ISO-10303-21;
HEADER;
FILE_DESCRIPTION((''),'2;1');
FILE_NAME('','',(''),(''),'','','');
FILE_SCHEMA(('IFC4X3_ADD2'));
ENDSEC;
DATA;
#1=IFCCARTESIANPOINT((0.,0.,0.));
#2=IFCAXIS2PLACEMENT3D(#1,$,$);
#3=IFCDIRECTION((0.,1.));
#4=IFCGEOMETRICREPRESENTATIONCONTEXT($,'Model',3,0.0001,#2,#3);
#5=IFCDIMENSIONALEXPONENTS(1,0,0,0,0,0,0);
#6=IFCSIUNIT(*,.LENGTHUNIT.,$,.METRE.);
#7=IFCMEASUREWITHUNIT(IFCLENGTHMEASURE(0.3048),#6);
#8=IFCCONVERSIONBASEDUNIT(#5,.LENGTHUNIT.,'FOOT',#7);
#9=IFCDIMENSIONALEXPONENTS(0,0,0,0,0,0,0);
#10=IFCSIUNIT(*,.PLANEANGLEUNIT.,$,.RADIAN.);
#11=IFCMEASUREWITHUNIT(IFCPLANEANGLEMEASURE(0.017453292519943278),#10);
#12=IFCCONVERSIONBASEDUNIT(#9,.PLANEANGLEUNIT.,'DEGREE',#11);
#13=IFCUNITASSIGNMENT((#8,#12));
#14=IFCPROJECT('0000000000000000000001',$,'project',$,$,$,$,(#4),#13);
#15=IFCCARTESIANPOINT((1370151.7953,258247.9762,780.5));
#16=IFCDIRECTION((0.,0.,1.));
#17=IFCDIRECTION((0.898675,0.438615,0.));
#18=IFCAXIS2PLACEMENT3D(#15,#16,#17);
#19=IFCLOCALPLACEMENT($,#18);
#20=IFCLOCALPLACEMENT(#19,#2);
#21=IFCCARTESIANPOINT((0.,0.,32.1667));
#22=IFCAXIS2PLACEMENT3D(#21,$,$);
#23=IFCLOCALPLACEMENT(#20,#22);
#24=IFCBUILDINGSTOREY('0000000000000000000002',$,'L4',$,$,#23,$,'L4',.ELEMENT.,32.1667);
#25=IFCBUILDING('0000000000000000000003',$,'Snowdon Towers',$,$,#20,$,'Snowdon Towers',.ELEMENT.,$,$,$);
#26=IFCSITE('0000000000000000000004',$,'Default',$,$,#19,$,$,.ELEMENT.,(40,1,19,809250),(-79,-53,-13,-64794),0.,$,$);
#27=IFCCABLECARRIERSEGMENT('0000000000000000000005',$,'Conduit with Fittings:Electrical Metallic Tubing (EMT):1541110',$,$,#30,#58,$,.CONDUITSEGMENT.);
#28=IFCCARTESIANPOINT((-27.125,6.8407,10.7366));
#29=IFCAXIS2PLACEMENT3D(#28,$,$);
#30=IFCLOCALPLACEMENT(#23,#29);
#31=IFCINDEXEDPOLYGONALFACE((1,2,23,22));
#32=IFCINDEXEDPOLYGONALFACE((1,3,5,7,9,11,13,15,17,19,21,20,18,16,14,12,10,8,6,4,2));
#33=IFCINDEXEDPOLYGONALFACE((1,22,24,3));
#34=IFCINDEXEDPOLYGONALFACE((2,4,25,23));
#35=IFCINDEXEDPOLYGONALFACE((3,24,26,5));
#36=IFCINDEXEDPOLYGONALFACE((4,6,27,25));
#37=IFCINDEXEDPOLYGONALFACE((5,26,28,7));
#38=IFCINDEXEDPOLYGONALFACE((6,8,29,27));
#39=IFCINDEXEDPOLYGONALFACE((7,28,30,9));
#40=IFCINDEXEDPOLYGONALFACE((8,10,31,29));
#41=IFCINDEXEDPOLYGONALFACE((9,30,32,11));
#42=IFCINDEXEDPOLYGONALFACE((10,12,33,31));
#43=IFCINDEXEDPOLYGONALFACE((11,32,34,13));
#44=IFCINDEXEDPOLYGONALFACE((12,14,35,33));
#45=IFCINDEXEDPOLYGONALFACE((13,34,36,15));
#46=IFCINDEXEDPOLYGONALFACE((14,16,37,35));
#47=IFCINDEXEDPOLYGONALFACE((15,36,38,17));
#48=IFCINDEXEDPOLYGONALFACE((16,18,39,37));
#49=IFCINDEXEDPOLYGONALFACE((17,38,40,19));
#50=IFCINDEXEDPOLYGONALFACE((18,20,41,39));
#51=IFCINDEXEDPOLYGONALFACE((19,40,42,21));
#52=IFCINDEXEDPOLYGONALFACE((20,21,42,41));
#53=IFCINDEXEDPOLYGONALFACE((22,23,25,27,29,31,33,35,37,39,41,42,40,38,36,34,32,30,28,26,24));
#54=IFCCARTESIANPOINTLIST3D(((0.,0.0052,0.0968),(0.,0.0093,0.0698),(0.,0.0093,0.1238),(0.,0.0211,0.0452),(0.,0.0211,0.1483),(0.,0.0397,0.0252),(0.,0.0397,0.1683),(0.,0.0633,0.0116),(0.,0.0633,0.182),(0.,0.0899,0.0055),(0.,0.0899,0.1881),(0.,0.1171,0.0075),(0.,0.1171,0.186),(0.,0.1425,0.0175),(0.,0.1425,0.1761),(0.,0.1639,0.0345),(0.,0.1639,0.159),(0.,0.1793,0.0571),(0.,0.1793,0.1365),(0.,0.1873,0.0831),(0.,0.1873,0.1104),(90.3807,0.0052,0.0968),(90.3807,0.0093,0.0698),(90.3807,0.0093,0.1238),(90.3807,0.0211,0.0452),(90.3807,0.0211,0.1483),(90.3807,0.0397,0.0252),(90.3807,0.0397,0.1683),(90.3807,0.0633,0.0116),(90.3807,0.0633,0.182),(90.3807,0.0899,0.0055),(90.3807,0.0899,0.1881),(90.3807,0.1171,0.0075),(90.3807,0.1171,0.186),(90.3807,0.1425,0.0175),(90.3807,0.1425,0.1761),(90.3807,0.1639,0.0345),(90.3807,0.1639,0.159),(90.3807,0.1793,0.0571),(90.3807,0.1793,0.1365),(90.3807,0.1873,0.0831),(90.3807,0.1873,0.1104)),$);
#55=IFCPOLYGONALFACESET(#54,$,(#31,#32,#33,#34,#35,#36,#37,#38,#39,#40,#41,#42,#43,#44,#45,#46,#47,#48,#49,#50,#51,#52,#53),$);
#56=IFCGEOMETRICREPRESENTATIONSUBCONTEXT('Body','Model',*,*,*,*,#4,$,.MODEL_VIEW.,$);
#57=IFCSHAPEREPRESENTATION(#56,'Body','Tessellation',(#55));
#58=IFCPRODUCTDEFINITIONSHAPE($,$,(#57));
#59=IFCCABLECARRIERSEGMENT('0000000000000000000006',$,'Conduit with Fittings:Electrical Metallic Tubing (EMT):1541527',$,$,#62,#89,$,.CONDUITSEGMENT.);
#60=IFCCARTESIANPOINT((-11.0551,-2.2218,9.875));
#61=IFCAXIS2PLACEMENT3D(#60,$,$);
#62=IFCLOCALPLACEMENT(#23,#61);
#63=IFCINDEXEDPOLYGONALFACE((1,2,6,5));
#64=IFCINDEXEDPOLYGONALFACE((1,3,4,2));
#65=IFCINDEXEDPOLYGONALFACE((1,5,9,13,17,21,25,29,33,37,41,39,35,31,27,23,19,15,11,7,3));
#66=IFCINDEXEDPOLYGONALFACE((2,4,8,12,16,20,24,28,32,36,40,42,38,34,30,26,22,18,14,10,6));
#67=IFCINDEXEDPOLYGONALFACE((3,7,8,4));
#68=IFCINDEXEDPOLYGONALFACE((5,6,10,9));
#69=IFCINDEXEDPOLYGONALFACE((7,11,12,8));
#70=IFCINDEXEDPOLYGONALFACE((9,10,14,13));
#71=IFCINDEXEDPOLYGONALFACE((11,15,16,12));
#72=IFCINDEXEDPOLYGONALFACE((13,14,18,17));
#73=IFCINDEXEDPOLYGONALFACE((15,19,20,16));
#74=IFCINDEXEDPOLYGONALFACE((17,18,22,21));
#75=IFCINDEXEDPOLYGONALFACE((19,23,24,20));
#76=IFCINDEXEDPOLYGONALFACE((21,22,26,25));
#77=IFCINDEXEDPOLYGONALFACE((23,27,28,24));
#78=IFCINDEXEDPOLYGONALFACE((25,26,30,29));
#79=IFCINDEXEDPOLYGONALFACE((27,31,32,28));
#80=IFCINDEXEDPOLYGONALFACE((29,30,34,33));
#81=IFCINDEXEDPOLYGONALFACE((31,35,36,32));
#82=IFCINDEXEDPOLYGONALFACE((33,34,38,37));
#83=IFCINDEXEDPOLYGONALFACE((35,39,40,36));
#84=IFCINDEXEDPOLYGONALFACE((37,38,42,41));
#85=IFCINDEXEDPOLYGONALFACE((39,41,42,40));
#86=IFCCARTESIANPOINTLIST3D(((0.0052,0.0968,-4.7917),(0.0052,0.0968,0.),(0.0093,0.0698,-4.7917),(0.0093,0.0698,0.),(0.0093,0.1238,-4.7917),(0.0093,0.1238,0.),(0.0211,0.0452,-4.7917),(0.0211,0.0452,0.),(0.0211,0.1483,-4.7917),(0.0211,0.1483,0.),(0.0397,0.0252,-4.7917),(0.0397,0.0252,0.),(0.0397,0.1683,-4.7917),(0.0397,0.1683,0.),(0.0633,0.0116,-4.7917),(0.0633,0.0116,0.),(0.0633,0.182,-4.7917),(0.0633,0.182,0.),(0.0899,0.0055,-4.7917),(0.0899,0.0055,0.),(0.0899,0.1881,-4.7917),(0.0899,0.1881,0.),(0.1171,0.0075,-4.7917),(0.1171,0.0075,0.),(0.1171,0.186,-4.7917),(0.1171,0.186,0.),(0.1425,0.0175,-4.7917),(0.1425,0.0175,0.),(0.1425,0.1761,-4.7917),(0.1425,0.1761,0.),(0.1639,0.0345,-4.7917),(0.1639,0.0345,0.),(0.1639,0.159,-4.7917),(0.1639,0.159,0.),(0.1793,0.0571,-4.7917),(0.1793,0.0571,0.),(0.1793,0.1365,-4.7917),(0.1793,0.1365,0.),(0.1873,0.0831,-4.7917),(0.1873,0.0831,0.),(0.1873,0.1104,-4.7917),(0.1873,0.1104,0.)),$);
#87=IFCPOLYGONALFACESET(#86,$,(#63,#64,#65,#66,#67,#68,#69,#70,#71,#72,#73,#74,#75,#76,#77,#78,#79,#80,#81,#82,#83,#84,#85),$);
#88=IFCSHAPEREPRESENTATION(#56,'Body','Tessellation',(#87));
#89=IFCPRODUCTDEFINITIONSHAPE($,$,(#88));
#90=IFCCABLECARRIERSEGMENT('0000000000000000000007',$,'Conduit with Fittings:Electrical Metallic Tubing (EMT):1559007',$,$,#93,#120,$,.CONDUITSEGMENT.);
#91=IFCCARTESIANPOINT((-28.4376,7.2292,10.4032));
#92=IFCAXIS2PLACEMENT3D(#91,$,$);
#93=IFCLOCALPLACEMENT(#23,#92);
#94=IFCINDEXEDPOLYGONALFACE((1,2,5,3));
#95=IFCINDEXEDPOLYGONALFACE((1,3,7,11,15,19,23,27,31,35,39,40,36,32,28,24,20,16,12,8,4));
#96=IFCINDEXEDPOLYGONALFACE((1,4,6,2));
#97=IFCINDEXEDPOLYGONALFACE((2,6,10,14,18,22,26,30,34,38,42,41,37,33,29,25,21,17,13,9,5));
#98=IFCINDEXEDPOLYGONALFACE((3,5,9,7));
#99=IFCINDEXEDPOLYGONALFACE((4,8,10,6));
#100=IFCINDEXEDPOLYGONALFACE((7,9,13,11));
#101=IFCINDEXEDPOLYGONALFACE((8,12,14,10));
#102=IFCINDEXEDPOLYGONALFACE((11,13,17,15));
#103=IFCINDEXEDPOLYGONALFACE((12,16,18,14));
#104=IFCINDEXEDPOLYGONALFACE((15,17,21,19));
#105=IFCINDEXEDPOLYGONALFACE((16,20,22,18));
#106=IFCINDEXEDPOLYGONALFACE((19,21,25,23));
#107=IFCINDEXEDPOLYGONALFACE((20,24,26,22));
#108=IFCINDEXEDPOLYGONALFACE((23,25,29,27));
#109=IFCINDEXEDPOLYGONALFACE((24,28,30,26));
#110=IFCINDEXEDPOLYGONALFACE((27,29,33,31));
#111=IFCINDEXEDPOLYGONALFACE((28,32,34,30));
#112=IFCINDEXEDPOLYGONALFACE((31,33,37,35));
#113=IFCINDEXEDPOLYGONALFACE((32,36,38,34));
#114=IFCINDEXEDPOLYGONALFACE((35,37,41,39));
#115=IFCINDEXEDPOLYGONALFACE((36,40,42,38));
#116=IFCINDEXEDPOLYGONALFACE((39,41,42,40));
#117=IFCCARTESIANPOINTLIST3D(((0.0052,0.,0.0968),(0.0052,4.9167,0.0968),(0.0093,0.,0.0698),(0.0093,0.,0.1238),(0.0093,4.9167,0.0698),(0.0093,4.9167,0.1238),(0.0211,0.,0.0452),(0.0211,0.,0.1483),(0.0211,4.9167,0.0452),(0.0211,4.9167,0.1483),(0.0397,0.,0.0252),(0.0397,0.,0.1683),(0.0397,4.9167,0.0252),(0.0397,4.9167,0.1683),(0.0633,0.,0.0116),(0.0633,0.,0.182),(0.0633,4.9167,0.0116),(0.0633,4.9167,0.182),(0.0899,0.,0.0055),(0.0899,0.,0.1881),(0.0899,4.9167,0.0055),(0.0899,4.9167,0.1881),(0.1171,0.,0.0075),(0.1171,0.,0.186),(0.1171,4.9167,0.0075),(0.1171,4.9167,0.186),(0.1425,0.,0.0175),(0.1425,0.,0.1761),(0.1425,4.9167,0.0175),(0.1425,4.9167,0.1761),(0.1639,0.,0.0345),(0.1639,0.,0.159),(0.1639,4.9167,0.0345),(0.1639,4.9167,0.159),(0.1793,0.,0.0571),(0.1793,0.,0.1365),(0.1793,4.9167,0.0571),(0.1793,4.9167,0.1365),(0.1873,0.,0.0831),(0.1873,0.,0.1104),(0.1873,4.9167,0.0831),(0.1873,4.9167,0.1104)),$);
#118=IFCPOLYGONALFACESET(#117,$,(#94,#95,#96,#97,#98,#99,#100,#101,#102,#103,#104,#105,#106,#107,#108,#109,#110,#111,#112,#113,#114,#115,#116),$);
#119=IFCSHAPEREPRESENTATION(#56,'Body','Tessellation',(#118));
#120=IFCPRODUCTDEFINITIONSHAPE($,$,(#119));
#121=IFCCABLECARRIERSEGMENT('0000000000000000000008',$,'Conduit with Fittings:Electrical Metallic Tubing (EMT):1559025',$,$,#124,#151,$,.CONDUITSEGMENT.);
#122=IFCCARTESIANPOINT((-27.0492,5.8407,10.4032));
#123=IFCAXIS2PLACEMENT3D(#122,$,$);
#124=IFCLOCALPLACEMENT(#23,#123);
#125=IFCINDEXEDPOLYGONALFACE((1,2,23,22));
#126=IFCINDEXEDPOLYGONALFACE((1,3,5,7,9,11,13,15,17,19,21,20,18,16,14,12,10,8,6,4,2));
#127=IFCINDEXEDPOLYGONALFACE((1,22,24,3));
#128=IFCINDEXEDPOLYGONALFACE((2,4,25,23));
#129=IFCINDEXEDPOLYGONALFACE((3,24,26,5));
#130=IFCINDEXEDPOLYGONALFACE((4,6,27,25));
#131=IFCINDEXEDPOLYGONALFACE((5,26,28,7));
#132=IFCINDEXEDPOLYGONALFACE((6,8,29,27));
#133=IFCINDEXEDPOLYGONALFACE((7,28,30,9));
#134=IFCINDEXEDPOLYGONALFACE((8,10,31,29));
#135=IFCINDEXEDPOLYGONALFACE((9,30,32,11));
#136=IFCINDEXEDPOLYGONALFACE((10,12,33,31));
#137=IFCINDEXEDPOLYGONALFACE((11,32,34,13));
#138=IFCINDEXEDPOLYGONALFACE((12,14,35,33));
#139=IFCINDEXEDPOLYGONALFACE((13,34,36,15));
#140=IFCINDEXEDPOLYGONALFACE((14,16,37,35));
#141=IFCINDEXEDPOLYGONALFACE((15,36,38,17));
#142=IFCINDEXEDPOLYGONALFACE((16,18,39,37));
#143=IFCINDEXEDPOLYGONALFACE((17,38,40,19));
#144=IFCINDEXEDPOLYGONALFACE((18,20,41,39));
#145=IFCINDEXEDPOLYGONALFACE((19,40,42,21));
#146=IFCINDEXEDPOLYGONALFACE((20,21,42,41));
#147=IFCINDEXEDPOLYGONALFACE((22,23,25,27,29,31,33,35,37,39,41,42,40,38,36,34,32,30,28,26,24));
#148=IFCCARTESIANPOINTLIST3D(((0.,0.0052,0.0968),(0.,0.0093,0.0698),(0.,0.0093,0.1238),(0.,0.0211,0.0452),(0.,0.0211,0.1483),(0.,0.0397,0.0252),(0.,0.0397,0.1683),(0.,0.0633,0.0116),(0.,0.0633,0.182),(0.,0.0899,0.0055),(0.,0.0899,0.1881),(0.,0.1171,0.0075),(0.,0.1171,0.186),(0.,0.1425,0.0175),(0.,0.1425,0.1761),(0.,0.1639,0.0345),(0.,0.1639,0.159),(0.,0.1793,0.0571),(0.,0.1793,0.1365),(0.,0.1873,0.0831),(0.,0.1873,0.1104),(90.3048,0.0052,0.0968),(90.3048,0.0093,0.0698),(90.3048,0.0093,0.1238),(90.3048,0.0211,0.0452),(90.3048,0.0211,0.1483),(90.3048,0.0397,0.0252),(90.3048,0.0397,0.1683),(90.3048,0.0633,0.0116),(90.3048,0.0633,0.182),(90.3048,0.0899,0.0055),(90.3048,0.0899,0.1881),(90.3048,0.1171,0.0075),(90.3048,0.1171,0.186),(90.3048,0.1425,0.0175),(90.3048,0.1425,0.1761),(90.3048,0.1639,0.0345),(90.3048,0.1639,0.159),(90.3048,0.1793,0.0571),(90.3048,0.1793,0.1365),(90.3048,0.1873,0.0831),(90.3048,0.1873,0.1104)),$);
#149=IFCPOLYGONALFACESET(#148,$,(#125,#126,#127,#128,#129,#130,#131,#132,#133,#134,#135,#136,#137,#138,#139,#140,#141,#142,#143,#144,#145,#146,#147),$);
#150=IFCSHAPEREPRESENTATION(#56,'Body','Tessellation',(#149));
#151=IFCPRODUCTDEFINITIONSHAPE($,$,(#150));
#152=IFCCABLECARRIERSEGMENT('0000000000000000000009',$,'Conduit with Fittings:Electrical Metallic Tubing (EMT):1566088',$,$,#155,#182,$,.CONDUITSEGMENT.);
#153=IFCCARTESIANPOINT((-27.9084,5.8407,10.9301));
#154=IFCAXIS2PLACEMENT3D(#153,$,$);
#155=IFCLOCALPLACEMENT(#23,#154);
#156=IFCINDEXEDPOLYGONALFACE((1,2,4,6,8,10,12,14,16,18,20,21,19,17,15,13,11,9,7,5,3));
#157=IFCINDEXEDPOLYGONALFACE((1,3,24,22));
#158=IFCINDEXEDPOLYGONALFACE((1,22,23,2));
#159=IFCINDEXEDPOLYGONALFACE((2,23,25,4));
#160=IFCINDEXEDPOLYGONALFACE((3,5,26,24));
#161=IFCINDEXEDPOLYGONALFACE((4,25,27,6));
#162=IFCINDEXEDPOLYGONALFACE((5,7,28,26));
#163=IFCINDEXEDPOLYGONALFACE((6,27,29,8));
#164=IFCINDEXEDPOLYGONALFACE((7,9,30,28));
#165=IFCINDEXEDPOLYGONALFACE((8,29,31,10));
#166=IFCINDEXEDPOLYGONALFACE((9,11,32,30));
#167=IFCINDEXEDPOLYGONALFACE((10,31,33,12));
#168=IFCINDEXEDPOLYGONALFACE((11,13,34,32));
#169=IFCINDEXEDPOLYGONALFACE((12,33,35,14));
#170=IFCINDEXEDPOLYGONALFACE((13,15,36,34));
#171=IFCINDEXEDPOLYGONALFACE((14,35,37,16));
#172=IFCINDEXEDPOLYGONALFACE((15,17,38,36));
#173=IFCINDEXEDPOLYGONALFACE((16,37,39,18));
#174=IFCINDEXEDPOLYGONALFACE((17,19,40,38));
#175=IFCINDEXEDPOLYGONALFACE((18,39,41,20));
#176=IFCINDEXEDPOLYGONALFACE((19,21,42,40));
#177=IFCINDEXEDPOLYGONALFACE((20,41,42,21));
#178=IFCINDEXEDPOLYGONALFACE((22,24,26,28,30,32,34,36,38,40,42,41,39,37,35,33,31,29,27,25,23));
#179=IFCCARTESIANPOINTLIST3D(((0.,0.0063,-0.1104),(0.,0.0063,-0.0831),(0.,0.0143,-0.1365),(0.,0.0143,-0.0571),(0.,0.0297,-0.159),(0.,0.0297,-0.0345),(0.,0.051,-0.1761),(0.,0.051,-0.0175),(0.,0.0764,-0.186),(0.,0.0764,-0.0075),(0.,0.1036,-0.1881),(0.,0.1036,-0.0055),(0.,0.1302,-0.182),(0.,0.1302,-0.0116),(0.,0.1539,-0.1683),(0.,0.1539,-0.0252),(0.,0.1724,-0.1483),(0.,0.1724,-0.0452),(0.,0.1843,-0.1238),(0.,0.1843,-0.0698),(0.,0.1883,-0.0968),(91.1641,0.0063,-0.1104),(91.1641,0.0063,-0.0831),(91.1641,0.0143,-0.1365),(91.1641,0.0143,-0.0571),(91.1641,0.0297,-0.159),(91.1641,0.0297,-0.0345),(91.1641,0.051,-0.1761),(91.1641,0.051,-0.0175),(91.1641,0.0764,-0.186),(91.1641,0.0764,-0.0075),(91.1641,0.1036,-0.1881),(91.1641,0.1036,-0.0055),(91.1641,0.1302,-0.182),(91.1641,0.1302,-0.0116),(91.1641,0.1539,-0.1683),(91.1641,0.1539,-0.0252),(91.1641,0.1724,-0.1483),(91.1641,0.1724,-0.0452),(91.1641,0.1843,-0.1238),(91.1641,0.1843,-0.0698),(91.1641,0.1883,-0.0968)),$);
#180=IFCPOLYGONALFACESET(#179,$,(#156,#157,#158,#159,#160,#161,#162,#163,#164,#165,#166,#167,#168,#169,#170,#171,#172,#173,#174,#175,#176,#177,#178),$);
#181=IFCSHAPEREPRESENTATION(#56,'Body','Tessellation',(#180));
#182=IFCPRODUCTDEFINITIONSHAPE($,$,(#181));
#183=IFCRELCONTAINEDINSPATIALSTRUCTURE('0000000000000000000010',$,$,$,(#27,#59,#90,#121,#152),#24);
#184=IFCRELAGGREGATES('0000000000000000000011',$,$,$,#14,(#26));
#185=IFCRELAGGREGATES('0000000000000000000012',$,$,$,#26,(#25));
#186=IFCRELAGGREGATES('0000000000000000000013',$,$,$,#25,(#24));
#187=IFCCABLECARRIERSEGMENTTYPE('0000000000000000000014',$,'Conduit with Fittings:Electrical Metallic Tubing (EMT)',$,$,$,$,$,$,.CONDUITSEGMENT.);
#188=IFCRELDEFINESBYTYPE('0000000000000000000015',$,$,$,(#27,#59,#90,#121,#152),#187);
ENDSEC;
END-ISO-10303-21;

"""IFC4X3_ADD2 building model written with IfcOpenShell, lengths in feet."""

from ifc_helpers import new_model, entity, si_unit, converted_unit, direction, frame, frame_2d, origin, place, context, subcontext, project, spatial, circle, extrude, type_object, element, save


model = new_model("IFC4X3_ADD2")

# Units and contexts
model_context = context("Model", 3, precision=0.0001, world=origin(), true_north=direction((0.0, 1.0)))
body_context = subcontext(model_context, "Body", "Model", "MODEL_VIEW")
ifc_project = project(units=[converted_unit("LENGTHUNIT", "FOOT", entity("IfcLengthMeasure", 0.3048), si_unit("LENGTHUNIT", "METRE"), dimensions=[1, 0, 0, 0, 0, 0, 0]), converted_unit("PLANEANGLEUNIT", "DEGREE", entity("IfcPlaneAngleMeasure", 0.017453292519943278), si_unit("PLANEANGLEUNIT", "RADIAN"), dimensions=[0, 0, 0, 0, 0, 0, 0])], contexts=[model_context])

# Site, building, storey
site_placement = place(None, frame((1370151.7953, 258247.9762, 780.5), z_axis=(0.0, 0.0, 1.0), x_axis=(0.898675, 0.438615, 0.0)))
site = spatial("IfcSite", under=ifc_project, at=site_placement, Name="Default", CompositionType="ELEMENT", RefLatitude=(40, 1, 19, 809250), RefLongitude=(-79, -53, -13, -64794), RefElevation=0.0)
building_placement = place(site_placement, origin())
building = spatial("IfcBuilding", under=site, at=building_placement, Name="Snowdon Towers", LongName="Snowdon Towers", CompositionType="ELEMENT")
storey_placement = place(building_placement, frame((0.0, 0.0, 32.1667)))
storey = spatial("IfcBuildingStorey", under=building, at=storey_placement, Name="L4", LongName="L4", CompositionType="ELEMENT", Elevation=32.1667)

# Cable carrier segments
cable_carrier_segment_type = type_object("IfcCableCarrierSegmentType", Name="Conduit with Fittings:Electrical Metallic Tubing (EMT)", PredefinedType="CONDUITSEGMENT")
cable_carrier_segment_1_placement = place(storey_placement, frame((-27.125, 6.8407, 10.7366)))
element("IfcCableCarrierSegment", 1, at=cable_carrier_segment_1_placement, inside=storey, type_object=cable_carrier_segment_type, Name="Conduit with Fittings:Electrical Metallic Tubing (EMT):1541110", PredefinedType="CONDUITSEGMENT", context=body_context, shape_type="SweptSolid", body=[
    extrude(circle(Radius=0.0915, at=frame_2d((0.0, 0.0), x_axis=(1.0, 0.0))), frame((0.0, 0.0968, 0.0968), z_axis=(1.0, 0.0, 0.0), x_axis=(0.0, -1.0, 0.0)), (0.0, 0.0, 1.0), 90.3807),
])
cable_carrier_segment_2_placement = place(storey_placement, frame((-11.0551, -2.2218, 9.875)))
element("IfcCableCarrierSegment", 2, at=cable_carrier_segment_2_placement, inside=storey, type_object=cable_carrier_segment_type, Name="Conduit with Fittings:Electrical Metallic Tubing (EMT):1541527", PredefinedType="CONDUITSEGMENT", context=body_context, shape_type="SweptSolid", body=[
    extrude(circle(Radius=0.0915, at=frame_2d((0.0, 0.0), x_axis=(1.0, 0.0))), frame((0.0968, 0.0968, -4.7917), z_axis=(0.0, 0.0, 1.0), x_axis=(-1.0, 0.0, 0.0)), (0.0, 0.0, 1.0), 4.7917),
])
cable_carrier_segment_3_placement = place(storey_placement, frame((-28.4376, 7.2292, 10.4032)))
element("IfcCableCarrierSegment", 3, at=cable_carrier_segment_3_placement, inside=storey, type_object=cable_carrier_segment_type, Name="Conduit with Fittings:Electrical Metallic Tubing (EMT):1559007", PredefinedType="CONDUITSEGMENT", context=body_context, shape_type="SweptSolid", body=[
    extrude(circle(Radius=0.0915, at=frame_2d((0.0, 0.0), x_axis=(1.0, 0.0))), frame((0.0968, 0.0, 0.0968), z_axis=(0.0, 1.0, 0.0), x_axis=(-1.0, 0.0, 0.0)), (0.0, 0.0, 1.0), 4.9167),
])
cable_carrier_segment_4_placement = place(storey_placement, frame((-27.0492, 5.8407, 10.4032)))
element("IfcCableCarrierSegment", 4, at=cable_carrier_segment_4_placement, inside=storey, type_object=cable_carrier_segment_type, Name="Conduit with Fittings:Electrical Metallic Tubing (EMT):1559025", PredefinedType="CONDUITSEGMENT", context=body_context, shape_type="SweptSolid", body=[
    extrude(circle(Radius=0.0915, at=frame_2d((0.0, 0.0), x_axis=(1.0, 0.0))), frame((0.0, 0.0968, 0.0968), z_axis=(1.0, 0.0, 0.0), x_axis=(0.0, -1.0, 0.0)), (0.0, 0.0, 1.0), 90.3048),
])
cable_carrier_segment_5_placement = place(storey_placement, frame((-27.9084, 5.8407, 10.9301)))
element("IfcCableCarrierSegment", 5, at=cable_carrier_segment_5_placement, inside=storey, type_object=cable_carrier_segment_type, Name="Conduit with Fittings:Electrical Metallic Tubing (EMT):1566088", PredefinedType="CONDUITSEGMENT", context=body_context, shape_type="SweptSolid", body=[
    extrude(circle(Radius=0.0915, at=frame_2d((0.0, 0.0), x_axis=(1.0, 0.0))), frame((0.0, 0.0968, -0.0968), z_axis=(1.0, 0.0, 0.0), x_axis=(0.0, 1.0, 0.0)), (0.0, 0.0, 1.0), 91.1641),
])

save(model, "model.ifc")
